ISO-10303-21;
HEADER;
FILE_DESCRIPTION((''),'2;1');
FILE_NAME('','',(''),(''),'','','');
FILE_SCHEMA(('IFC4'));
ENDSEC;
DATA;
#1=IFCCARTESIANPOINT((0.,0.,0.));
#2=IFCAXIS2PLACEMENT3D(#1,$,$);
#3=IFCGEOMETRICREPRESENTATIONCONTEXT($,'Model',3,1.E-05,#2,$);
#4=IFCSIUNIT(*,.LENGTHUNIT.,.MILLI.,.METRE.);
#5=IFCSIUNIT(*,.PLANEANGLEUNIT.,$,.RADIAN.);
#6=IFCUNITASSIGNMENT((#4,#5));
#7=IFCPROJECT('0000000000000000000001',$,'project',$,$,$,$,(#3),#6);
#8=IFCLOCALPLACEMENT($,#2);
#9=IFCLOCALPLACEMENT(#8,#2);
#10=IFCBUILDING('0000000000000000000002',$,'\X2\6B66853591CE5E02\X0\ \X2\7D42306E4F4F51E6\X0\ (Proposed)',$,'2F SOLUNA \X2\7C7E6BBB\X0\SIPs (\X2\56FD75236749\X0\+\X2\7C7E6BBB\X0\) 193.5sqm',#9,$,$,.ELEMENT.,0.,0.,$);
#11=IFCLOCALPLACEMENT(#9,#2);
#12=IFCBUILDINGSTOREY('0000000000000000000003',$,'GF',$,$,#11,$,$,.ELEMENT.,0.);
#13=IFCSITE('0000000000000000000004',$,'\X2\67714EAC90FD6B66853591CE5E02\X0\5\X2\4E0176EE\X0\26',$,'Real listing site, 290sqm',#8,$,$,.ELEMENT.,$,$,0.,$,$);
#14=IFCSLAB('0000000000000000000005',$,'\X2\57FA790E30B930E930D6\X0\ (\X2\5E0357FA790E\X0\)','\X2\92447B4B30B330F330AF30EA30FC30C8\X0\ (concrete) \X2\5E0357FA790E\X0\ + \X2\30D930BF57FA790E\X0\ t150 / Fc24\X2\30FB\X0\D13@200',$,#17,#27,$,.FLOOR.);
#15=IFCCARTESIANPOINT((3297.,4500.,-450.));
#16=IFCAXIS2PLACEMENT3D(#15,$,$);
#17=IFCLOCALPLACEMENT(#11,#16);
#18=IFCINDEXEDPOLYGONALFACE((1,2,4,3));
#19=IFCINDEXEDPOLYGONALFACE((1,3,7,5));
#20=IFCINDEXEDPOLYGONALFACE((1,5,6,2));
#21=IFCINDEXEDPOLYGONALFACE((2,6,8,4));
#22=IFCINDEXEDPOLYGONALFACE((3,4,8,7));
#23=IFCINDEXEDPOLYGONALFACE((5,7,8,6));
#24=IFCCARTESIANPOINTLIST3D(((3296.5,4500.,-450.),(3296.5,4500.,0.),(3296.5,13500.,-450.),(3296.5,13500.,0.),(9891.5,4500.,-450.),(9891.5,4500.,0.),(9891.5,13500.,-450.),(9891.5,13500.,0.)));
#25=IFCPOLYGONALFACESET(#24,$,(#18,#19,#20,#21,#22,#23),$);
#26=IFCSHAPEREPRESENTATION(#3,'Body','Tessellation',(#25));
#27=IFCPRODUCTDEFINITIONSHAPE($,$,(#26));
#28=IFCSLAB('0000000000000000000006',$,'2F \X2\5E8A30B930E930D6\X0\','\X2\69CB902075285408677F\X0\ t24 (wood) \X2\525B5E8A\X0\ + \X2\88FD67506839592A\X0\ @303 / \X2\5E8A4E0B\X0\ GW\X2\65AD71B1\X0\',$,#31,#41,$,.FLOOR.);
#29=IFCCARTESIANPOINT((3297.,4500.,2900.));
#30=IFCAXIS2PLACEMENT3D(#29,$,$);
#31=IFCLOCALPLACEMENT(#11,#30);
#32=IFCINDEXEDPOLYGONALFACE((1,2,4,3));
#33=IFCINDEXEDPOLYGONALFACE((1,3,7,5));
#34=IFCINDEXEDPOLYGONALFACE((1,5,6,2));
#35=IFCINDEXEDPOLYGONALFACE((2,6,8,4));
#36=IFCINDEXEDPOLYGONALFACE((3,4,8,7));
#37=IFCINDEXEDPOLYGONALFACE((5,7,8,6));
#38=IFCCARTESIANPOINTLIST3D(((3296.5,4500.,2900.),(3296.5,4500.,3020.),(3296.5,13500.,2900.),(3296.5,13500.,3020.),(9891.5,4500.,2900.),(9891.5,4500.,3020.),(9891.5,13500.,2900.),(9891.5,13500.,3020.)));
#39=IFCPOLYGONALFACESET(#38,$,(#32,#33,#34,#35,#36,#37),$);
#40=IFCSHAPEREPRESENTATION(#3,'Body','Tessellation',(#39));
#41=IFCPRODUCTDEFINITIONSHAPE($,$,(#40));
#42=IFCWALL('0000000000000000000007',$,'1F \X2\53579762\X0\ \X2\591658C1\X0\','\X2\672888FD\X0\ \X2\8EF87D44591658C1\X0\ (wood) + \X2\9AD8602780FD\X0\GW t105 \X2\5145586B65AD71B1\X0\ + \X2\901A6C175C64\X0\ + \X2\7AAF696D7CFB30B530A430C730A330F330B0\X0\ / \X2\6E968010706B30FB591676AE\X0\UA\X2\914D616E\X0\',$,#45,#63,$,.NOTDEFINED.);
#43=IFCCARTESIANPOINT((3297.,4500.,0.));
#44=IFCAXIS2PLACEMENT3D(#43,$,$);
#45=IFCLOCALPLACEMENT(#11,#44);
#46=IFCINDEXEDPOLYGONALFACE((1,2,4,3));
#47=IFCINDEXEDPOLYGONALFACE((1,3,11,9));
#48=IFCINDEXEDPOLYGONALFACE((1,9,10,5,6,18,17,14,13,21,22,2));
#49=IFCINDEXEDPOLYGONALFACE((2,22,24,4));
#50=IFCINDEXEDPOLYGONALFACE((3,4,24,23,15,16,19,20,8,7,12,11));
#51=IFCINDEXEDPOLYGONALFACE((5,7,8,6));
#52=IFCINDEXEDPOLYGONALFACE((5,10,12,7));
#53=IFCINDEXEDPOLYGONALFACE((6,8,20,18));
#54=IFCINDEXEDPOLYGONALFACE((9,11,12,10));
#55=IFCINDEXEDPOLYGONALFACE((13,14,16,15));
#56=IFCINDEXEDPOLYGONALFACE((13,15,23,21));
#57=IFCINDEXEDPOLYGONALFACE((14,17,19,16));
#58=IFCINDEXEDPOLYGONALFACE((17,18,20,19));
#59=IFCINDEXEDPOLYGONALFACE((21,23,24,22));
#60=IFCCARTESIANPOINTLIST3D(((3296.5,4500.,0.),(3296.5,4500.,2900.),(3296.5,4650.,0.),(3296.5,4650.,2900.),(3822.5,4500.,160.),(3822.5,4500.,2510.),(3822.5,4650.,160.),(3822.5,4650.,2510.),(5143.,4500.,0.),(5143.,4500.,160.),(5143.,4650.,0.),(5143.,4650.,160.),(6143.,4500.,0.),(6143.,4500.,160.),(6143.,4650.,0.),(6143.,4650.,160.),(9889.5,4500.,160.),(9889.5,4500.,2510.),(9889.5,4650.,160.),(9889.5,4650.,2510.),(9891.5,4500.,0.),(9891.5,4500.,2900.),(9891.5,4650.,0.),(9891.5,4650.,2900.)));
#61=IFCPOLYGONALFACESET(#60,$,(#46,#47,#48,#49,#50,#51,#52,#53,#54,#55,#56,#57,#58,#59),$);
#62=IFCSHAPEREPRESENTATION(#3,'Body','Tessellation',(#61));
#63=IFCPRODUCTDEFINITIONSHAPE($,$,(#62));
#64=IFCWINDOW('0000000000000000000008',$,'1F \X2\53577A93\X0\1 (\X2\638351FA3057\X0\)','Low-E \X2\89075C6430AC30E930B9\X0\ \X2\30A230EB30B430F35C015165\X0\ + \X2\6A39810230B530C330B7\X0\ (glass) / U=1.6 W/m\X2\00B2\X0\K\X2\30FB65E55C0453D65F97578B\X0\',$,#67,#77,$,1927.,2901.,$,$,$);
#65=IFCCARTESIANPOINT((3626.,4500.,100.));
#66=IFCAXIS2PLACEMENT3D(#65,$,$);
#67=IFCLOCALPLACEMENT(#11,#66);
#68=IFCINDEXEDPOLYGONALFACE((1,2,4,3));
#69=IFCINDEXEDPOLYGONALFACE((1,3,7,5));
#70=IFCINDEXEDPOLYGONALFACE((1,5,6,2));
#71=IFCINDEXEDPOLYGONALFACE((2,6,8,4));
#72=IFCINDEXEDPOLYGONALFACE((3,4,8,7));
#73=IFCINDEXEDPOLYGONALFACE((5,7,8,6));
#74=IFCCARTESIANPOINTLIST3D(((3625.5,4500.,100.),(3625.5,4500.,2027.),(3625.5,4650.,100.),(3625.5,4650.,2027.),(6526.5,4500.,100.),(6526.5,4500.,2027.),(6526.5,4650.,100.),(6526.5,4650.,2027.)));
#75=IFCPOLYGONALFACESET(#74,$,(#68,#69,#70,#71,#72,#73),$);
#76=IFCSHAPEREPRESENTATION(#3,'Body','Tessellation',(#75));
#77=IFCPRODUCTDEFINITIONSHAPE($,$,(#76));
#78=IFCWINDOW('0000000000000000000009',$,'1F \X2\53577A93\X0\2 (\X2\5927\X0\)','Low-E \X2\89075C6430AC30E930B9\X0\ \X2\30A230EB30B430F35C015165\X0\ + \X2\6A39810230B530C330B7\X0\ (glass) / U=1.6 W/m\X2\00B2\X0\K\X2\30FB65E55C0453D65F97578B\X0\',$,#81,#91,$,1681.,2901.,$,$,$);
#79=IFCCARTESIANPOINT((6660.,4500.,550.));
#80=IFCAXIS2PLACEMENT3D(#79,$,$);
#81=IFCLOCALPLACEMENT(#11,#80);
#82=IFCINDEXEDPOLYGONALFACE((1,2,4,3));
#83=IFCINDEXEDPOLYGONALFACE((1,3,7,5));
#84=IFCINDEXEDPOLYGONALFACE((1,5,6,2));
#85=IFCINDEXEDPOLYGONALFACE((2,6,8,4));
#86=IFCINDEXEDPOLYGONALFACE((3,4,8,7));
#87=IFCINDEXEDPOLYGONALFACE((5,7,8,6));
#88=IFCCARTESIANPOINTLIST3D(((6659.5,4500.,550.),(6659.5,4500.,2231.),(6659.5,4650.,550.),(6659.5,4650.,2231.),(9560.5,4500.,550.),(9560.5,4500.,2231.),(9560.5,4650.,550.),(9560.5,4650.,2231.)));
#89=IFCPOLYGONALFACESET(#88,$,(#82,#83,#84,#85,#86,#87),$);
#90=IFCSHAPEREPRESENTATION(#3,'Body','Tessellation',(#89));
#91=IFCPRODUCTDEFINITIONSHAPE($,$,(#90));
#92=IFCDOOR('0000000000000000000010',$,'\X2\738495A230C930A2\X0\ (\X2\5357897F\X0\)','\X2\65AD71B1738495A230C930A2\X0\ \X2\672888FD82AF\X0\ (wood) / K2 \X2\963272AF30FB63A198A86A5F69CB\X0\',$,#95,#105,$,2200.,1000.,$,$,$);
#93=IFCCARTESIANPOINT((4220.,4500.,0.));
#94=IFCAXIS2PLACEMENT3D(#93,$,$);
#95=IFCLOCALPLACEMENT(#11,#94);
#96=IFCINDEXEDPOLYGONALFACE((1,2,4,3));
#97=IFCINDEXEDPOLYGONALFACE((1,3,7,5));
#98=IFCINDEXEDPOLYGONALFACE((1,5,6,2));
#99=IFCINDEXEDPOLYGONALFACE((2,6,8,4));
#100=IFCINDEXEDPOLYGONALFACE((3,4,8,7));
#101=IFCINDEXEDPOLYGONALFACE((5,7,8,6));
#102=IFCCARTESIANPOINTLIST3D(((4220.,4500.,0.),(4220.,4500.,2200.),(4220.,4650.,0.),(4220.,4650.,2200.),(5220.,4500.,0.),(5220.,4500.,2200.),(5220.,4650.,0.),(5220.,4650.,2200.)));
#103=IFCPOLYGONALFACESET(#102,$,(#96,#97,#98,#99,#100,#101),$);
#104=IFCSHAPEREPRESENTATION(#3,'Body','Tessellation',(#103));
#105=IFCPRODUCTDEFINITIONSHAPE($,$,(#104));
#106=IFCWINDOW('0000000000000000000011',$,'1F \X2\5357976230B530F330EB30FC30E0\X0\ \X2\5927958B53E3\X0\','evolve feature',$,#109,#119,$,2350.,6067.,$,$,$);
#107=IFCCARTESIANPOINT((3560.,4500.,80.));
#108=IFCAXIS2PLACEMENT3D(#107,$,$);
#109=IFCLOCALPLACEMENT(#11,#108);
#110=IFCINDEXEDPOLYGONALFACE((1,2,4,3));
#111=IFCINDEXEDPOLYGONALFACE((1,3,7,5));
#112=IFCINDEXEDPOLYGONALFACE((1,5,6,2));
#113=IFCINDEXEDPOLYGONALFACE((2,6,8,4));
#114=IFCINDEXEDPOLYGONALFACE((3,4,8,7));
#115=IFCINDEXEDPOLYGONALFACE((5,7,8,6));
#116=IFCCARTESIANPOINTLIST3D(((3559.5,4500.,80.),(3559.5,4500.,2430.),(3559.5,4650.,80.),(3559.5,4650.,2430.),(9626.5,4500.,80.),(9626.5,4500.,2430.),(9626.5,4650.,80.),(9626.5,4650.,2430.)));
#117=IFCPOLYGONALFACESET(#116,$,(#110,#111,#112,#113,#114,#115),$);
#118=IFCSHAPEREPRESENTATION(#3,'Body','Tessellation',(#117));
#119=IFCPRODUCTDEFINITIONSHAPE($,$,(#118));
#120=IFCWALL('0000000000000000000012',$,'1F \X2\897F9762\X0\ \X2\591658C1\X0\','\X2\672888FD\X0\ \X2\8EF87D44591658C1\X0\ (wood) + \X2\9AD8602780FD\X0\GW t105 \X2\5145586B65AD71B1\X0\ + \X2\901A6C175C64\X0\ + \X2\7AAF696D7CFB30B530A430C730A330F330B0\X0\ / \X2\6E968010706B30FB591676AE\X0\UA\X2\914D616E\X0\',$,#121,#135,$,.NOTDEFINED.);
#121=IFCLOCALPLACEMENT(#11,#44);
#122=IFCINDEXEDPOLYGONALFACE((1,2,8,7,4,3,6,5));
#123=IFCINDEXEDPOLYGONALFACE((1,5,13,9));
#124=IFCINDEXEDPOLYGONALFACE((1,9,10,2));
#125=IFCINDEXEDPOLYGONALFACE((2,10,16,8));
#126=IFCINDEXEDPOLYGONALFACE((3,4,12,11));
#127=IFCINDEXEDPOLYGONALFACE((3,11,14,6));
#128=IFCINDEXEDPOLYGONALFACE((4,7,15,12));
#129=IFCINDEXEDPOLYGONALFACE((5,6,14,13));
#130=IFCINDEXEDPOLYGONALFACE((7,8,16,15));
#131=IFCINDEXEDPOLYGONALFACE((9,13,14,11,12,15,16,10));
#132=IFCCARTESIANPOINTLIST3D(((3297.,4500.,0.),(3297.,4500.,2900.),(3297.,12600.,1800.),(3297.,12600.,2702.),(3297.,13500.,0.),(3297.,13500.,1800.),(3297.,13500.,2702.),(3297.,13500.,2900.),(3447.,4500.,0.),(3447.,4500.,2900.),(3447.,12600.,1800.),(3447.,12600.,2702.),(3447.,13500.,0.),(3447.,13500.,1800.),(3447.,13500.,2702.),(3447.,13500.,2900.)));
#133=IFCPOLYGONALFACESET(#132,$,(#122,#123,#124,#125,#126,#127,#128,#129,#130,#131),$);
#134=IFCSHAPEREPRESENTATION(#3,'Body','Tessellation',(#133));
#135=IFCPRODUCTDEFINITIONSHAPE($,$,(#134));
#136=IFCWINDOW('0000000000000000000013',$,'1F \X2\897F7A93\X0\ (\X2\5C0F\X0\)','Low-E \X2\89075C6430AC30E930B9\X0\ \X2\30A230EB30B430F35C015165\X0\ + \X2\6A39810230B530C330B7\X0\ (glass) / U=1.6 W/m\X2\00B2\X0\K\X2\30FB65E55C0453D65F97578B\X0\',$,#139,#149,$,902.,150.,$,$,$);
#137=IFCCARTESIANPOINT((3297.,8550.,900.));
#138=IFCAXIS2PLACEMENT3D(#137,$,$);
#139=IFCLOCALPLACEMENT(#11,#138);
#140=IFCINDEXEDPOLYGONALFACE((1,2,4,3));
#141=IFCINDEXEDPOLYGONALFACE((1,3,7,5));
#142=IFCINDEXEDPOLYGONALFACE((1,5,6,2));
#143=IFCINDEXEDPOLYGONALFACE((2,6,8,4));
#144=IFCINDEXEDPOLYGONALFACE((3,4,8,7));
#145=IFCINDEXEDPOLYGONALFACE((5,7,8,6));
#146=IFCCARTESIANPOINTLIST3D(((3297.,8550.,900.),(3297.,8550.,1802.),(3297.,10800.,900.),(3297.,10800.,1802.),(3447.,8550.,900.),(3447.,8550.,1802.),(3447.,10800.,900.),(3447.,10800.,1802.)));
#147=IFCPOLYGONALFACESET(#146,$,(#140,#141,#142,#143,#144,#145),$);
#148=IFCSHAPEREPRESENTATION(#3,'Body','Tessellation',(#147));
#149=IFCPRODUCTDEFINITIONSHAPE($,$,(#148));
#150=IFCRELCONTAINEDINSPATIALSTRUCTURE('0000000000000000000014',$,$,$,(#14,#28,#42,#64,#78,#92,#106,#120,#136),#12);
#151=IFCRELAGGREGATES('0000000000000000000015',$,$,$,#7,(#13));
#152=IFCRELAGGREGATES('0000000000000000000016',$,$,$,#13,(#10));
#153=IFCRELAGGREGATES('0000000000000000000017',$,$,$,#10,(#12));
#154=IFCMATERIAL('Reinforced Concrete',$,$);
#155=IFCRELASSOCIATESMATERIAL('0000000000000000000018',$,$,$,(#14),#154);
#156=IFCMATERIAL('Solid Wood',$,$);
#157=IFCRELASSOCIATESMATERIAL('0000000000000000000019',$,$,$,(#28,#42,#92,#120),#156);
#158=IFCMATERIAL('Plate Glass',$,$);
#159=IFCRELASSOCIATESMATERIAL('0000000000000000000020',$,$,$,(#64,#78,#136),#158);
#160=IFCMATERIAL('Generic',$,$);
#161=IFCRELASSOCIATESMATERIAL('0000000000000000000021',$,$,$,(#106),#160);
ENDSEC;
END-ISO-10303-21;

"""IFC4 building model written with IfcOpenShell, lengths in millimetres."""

from ifc_helpers import new_model, si_unit, frame, frame_2d, origin, place, context, project, spatial, rectangle, extrude, material, element, fill, save


model = new_model("IFC4")

# Units and contexts
model_context = context("Model", 3, precision=1e-05, world=origin())
ifc_project = project(units=[si_unit("LENGTHUNIT", "METRE", prefix="MILLI"), si_unit("PLANEANGLEUNIT", "RADIAN")], contexts=[model_context])

# Site, building, storey
site_placement = place(None, origin())
site = spatial("IfcSite", under=ifc_project, at=site_placement, Name="東京都武蔵野市5丁目26", ObjectType="Real listing site, 290sqm", CompositionType="ELEMENT", RefElevation=0.0)
building_placement = place(site_placement, origin())
building = spatial("IfcBuilding", under=site, at=building_placement, Name="武蔵野市 終の住処 (Proposed)", ObjectType="2F SOLUNA 籾殻SIPs (国産杉+籾殻) 193.5sqm", CompositionType="ELEMENT", ElevationOfRefHeight=0.0, ElevationOfTerrain=0.0)
storey_placement = place(building_placement, origin())
storey = spatial("IfcBuildingStorey", under=building, at=storey_placement, Name="GF", CompositionType="ELEMENT", Elevation=0.0)

# Slabs
ifc_material_1 = material(Name="Reinforced Concrete")
slab_1_placement = place(storey_placement, frame((3297.0, 4500.0, -450.0)))
element("IfcSlab", 1, at=slab_1_placement, inside=storey, material=ifc_material_1, Name="基礎スラブ (布基礎)", Description="鉄筋コンクリート (concrete) 布基礎 + ベタ基礎 t150 / Fc24・D13@200", PredefinedType="FLOOR", context=model_context, shape_type="SweptSolid", body=[
    extrude(rectangle(XDim=6595.0, YDim=9000.0, at=frame_2d((3297.0, 4500.0))), frame((3297.0, 4500.0, -450.0)), (0.0, 0.0, 1.0), 450.0),
])
ifc_material_2 = material(Name="Solid Wood")
slab_2_placement = place(storey_placement, frame((3297.0, 4500.0, 2900.0)))
element("IfcSlab", 2, at=slab_2_placement, inside=storey, material=ifc_material_2, Name="2F 床スラブ", Description="構造用合板 t24 (wood) 剛床 + 製材根太 @303 / 床下 GW断熱", PredefinedType="FLOOR", context=model_context, shape_type="SweptSolid", body=[
    extrude(rectangle(XDim=6595.0, YDim=9000.0, at=frame_2d((3297.0, 4500.0))), frame((3297.0, 4500.0, 2900.0)), (0.0, 0.0, 1.0), 120.0),
])

# Wall, openings, windows, door
wall_1_placement = place(storey_placement, frame((3297.0, 4500.0, 0.0)))
wall_1 = element("IfcWall", 3, at=wall_1_placement, inside=storey, material=ifc_material_2, Name="1F 南面 外壁", Description="木製 軸組外壁 (wood) + 高性能GW t105 充填断熱 + 通気層 + 窯業系サイディング / 準耐火・外皮UA配慮", PredefinedType="NOTDEFINED", context=model_context, shape_type="SweptSolid", body=[
    extrude(rectangle(XDim=6595.0, YDim=150.0, at=frame_2d((3297.0, 75.0))), frame((3297.0, 4500.0, 0.0)), (0.0, 0.0, 1.0), 2900.0),
])
opening_1_placement = place(storey_placement, frame((3626.0, 4500.0, 100.0)))
opening_1 = element("IfcOpeningElement", 4, at=opening_1_placement, cuts=wall_1, PredefinedType="NOTDEFINED", context=model_context, shape_type="SweptSolid", body=[
    extrude(rectangle(XDim=2901.0, YDim=150.0, at=frame_2d((1450.0, 75.0))), frame((3626.0, 4500.0, 100.0)), (0.0, 0.0, 1.0), 1927.0),
])
opening_2_placement = place(storey_placement, frame((6660.0, 4500.0, 550.0)))
opening_2 = element("IfcOpeningElement", 5, at=opening_2_placement, cuts=wall_1, PredefinedType="NOTDEFINED", context=model_context, shape_type="SweptSolid", body=[
    extrude(rectangle(XDim=2901.0, YDim=150.0, at=frame_2d((1450.0, 75.0))), frame((6660.0, 4500.0, 550.0)), (0.0, 0.0, 1.0), 1681.0),
])
opening_3_placement = place(storey_placement, frame((4220.0, 4500.0, 0.0)))
opening_3 = element("IfcOpeningElement", 6, at=opening_3_placement, cuts=wall_1, PredefinedType="NOTDEFINED", context=model_context, shape_type="SweptSolid", body=[
    extrude(rectangle(XDim=1000.0, YDim=150.0, at=frame_2d((500.0, 75.0))), frame((4220.0, 4500.0, 0.0)), (0.0, 0.0, 1.0), 2200.0),
])
opening_4_placement = place(storey_placement, frame((3560.0, 4500.0, 80.0)))
opening_4 = element("IfcOpeningElement", 7, at=opening_4_placement, cuts=wall_1, PredefinedType="NOTDEFINED", context=model_context, shape_type="SweptSolid", body=[
    extrude(rectangle(XDim=6067.0, YDim=150.0, at=frame_2d((3033.0, 75.0))), frame((3560.0, 4500.0, 80.0)), (0.0, 0.0, 1.0), 2350.0),
])
ifc_material_3 = material(Name="Plate Glass")
window_1_placement = place(storey_placement, frame((3626.0, 4500.0, 100.0)))
window_1 = element("IfcWindow", 8, at=window_1_placement, inside=storey, material=ifc_material_3, Name="1F 南窓1 (掃出し)", Description="Low-E 複層ガラス アルゴン封入 + 樹脂サッシ (glass) / U=1.6 W/m²K・日射取得型", OverallHeight=1927.0, OverallWidth=2901.0, context=model_context, shape_type="SweptSolid", body=[
    extrude(rectangle(XDim=2901.0, YDim=150.0, at=frame_2d((1450.0, 75.0))), frame((3626.0, 4500.0, 100.0)), (0.0, 0.0, 1.0), 1927.0),
])
fill(opening_1, window_1)
window_2_placement = place(storey_placement, frame((6660.0, 4500.0, 550.0)))
window_2 = element("IfcWindow", 9, at=window_2_placement, inside=storey, material=ifc_material_3, Name="1F 南窓2 (大)", Description="Low-E 複層ガラス アルゴン封入 + 樹脂サッシ (glass) / U=1.6 W/m²K・日射取得型", OverallHeight=1681.0, OverallWidth=2901.0, context=model_context, shape_type="SweptSolid", body=[
    extrude(rectangle(XDim=2901.0, YDim=150.0, at=frame_2d((1450.0, 75.0))), frame((6660.0, 4500.0, 550.0)), (0.0, 0.0, 1.0), 1681.0),
])
fill(opening_2, window_2)
door_placement = place(storey_placement, frame((4220.0, 4500.0, 0.0)))
door = element("IfcDoor", 10, at=door_placement, inside=storey, material=ifc_material_2, Name="玄関ドア (南西)", Description="断熱玄関ドア 木製芯 (wood) / K2 防犯・採風機構", OverallHeight=2200.0, OverallWidth=1000.0, context=model_context, shape_type="SweptSolid", body=[
    extrude(rectangle(XDim=1000.0, YDim=150.0, at=frame_2d((500.0, 75.0))), frame((4220.0, 4500.0, 0.0)), (0.0, 0.0, 1.0), 2200.0),
])
fill(opening_3, door)
ifc_material_4 = material(Name="Generic")
window_3_placement = place(storey_placement, frame((3560.0, 4500.0, 80.0)))
window_3 = element("IfcWindow", 11, at=window_3_placement, inside=storey, material=ifc_material_4, Name="1F 南面サンルーム 大開口", Description="evolve feature", OverallHeight=2350.0, OverallWidth=6067.0, context=model_context, shape_type="SweptSolid", body=[
    extrude(rectangle(XDim=6067.0, YDim=150.0, at=frame_2d((3033.0, 75.0))), frame((3560.0, 4500.0, 80.0)), (0.0, 0.0, 1.0), 2350.0),
])
fill(opening_4, window_3)

# Wall, opening, window
wall_2_placement = place(storey_placement, frame((3297.0, 4500.0, 0.0)))
wall_2 = element("IfcWall", 12, at=wall_2_placement, inside=storey, material=ifc_material_2, Name="1F 西面 外壁", Description="木製 軸組外壁 (wood) + 高性能GW t105 充填断熱 + 通気層 + 窯業系サイディング / 準耐火・外皮UA配慮", PredefinedType="NOTDEFINED", context=model_context, shape_type="SweptSolid", body=[
    extrude(rectangle(XDim=150.0, YDim=9000.0, at=frame_2d((75.0, 4500.0))), frame((3297.0, 4500.0, 0.0)), (0.0, 0.0, 1.0), 2900.0),
])
opening_5_placement = place(storey_placement, frame((3297.0, 8550.0, 900.0)))
opening_5 = element("IfcOpeningElement", 13, at=opening_5_placement, cuts=wall_2, PredefinedType="NOTDEFINED", context=model_context, shape_type="SweptSolid", body=[
    extrude(rectangle(XDim=150.0, YDim=2250.0, at=frame_2d((75.0, 1125.0))), frame((3297.0, 8550.0, 900.0)), (0.0, 0.0, 1.0), 902.0),
])
window_4_placement = place(storey_placement, frame((3297.0, 8550.0, 900.0)))
window_4 = element("IfcWindow", 14, at=window_4_placement, inside=storey, material=ifc_material_3, Name="1F 西窓 (小)", Description="Low-E 複層ガラス アルゴン封入 + 樹脂サッシ (glass) / U=1.6 W/m²K・日射取得型", OverallHeight=902.0, OverallWidth=150.0, context=model_context, shape_type="SweptSolid", body=[
    extrude(rectangle(XDim=150.0, YDim=2250.0, at=frame_2d((75.0, 1125.0))), frame((3297.0, 8550.0, 900.0)), (0.0, 0.0, 1.0), 902.0),
])
fill(opening_5, window_4)

save(model, "model.ifc")
